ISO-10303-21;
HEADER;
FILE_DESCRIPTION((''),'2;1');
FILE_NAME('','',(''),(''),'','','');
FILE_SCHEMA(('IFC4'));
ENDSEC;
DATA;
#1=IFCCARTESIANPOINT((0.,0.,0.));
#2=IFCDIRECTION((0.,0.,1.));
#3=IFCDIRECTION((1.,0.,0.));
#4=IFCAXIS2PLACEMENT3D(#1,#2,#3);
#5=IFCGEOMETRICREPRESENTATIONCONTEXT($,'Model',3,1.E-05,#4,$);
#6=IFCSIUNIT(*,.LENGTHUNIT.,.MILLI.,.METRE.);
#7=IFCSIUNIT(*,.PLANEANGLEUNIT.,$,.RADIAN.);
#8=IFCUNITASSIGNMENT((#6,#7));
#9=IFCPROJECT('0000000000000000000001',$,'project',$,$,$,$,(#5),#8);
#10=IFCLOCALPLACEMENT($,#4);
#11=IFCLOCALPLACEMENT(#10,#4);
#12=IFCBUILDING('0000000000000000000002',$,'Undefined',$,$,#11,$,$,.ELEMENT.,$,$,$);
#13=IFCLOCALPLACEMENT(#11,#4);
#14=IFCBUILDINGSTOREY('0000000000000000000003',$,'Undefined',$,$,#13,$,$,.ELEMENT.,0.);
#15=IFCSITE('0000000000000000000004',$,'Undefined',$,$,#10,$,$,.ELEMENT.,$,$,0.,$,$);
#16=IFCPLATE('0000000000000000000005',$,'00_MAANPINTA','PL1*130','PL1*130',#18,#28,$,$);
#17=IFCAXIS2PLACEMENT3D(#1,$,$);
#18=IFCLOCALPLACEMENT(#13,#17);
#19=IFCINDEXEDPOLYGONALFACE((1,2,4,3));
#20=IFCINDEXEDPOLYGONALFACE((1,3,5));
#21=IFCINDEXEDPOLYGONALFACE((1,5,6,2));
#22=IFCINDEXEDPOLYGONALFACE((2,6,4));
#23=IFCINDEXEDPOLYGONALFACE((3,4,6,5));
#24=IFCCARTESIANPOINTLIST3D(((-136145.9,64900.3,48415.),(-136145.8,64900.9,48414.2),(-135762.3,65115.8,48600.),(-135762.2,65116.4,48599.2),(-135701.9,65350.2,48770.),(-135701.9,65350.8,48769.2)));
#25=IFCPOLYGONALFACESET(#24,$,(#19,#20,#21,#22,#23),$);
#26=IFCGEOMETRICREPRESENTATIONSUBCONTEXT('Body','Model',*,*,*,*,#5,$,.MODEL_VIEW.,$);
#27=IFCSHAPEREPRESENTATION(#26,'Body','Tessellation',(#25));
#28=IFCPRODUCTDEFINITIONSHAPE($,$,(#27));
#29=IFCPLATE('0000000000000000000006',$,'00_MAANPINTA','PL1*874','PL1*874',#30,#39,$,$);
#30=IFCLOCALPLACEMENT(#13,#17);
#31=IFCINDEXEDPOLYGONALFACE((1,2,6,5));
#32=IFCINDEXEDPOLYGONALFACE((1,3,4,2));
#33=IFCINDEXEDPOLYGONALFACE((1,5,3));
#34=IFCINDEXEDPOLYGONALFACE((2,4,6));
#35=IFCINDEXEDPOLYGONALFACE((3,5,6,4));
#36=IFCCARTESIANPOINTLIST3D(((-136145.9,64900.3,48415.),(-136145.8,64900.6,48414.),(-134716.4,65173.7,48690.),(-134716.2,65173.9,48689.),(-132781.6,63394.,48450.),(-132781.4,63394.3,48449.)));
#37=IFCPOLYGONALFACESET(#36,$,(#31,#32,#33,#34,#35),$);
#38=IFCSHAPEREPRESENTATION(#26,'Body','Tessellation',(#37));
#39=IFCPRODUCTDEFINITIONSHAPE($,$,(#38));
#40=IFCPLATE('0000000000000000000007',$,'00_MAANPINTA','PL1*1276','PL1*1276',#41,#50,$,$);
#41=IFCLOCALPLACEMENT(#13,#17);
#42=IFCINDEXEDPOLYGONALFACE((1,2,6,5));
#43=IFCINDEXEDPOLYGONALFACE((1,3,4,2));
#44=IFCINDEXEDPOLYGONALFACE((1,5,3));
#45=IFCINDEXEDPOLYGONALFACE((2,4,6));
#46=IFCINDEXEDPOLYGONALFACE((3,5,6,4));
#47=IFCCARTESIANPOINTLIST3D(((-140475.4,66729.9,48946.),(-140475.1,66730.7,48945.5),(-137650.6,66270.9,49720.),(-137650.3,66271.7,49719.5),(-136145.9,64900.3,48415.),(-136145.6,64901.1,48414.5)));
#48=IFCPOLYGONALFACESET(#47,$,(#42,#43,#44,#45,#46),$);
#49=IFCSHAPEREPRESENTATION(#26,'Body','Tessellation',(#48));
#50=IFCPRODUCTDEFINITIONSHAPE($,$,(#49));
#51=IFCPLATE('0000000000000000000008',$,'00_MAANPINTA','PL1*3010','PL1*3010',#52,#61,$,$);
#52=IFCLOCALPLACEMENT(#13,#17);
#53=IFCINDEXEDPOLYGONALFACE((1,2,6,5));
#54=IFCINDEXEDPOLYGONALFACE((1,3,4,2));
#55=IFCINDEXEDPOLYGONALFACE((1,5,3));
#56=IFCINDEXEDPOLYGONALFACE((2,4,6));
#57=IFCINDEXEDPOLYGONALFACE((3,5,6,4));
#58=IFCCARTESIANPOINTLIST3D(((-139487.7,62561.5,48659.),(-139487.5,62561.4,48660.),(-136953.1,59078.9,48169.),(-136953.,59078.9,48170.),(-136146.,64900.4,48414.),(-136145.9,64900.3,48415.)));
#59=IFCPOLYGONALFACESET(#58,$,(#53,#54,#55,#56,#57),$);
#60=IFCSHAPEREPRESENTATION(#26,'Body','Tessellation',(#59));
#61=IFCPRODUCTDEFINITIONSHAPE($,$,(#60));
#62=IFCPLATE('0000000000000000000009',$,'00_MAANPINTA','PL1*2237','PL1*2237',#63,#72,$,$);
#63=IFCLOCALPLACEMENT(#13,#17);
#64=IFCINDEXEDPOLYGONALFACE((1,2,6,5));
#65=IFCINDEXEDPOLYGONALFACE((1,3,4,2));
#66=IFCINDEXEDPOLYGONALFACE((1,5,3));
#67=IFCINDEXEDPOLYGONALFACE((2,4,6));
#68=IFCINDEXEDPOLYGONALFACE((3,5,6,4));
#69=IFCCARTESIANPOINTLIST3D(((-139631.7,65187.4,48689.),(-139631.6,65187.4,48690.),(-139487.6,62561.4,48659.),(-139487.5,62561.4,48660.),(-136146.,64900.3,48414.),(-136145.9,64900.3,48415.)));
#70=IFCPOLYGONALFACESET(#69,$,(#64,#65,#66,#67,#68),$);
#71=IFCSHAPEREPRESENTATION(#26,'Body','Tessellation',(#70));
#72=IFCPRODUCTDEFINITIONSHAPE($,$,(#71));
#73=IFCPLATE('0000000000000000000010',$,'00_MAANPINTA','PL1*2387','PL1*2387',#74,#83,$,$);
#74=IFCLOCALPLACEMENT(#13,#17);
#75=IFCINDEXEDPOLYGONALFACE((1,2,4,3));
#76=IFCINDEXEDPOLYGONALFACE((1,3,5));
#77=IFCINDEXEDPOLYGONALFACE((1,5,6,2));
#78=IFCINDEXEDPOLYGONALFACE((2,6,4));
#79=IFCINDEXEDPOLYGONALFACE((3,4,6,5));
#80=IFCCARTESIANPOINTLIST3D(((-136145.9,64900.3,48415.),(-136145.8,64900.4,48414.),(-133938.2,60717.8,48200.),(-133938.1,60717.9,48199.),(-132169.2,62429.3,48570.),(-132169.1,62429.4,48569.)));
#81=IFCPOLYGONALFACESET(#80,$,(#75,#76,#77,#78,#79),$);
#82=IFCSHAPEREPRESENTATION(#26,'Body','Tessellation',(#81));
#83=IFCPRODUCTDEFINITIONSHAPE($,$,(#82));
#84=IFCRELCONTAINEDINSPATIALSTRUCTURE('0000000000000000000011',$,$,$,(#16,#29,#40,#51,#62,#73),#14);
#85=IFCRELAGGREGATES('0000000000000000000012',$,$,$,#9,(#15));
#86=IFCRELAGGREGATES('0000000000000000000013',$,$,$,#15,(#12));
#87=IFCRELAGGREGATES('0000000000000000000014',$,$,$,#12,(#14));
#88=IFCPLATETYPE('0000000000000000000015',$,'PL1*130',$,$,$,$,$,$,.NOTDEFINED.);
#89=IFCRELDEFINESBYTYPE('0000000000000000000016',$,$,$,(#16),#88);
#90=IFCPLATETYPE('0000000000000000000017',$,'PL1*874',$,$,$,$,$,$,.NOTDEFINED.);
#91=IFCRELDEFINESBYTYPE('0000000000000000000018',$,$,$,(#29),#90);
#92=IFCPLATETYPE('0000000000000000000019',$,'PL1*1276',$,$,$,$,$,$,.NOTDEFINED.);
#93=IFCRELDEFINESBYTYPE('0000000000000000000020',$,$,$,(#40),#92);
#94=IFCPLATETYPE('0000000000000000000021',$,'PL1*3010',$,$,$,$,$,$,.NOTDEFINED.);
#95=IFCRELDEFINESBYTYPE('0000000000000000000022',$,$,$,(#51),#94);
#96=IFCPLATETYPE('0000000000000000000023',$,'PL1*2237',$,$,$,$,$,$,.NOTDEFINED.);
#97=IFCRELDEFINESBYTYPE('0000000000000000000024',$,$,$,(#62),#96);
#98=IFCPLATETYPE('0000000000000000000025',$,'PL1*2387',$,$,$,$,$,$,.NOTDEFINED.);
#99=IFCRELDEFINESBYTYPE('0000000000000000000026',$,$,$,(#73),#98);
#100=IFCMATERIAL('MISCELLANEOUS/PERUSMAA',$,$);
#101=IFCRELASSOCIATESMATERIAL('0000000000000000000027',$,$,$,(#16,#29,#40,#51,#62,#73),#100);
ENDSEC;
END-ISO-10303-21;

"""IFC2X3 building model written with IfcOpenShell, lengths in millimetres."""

from ifc_helpers import new_model, si_unit, frame, origin_with_axes, place, context, subcontext, project, spatial, polyline, outline, extrude, material, type_object, element, save


model = new_model("IFC2X3")

# Units and contexts
model_context = context("Model", 3, precision=1e-05, world=origin_with_axes())
body_context = subcontext(model_context, "Body", "Model", "MODEL_VIEW")
ifc_project = project(units=[si_unit("LENGTHUNIT", "METRE", prefix="MILLI"), si_unit("PLANEANGLEUNIT", "RADIAN")], contexts=[model_context])

# Site, building, storey
site_placement = place(None, origin_with_axes())
site = spatial("IfcSite", under=ifc_project, at=site_placement, Name="Undefined", CompositionType="ELEMENT", RefElevation=0.0)
building_placement = place(site_placement, origin_with_axes())
building = spatial("IfcBuilding", under=site, at=building_placement, Name="Undefined", CompositionType="ELEMENT")
storey_placement = place(building_placement, origin_with_axes())
storey = spatial("IfcBuildingStorey", under=building, at=storey_placement, Name="Undefined", CompositionType="ELEMENT", Elevation=0.0)

# Plates
ifc_material = material(Name="MISCELLANEOUS/PERUSMAA")
plate_type_1 = type_object("IfcPlateType", Name="PL1*130", PredefinedType="NOTDEFINED")
plate_1_placement = place(storey_placement, frame((-135762.3, 65116.1, 48599.6), z_axis=(0.071419, 0.573442, -0.816127), x_axis=(-0.803689, -0.451514, -0.387582)))
element("IfcPlate", 1, at=plate_1_placement, inside=storey, type_object=plate_type_1, material=ifc_material, Name="00_MAANPINTA", Description="PL1*130", ObjectType="PL1*130", context=body_context, shape_type="SweptSolid", body=[
    extrude(outline(polyline([(0.0, 0.0), (477.3, 0.0), (-220.3, 197.5), (0.0, 0.0)])), frame((0.0, 0.0, -0.5), z_axis=(0.0, 0.0, 1.0), x_axis=(1.0, 0.0, 0.0)), (0.0, 0.0, 1.0), 1.0),
])
plate_type_2 = type_object("IfcPlateType", Name="PL1*874", PredefinedType="NOTDEFINED")
plate_2_placement = place(storey_placement, frame((-136145.8, 64900.4, 48414.5), z_axis=(0.131484, 0.271523, -0.953408), x_axis=(0.965126, 0.184559, 0.185661)))
element("IfcPlate", 2, at=plate_2_placement, inside=storey, type_object=plate_type_2, material=ifc_material, Name="00_MAANPINTA", Description="PL1*874", ObjectType="PL1*874", context=body_context, shape_type="SweptSolid", body=[
    extrude(outline(polyline([(0.0, 0.0), (1481.2, 0.0), (2975.5, 2176.1), (0.0, 0.0)])), frame((0.0, 0.0, -0.5), z_axis=(0.0, 0.0, 1.0), x_axis=(1.0, 0.0, 0.0)), (0.0, 0.0, 1.0), 1.0),
])
plate_type_3 = type_object("IfcPlateType", Name="PL1*1276", PredefinedType="NOTDEFINED")
plate_3_placement = place(storey_placement, frame((-136145.8, 64900.7, 48414.7), z_axis=(0.275093, 0.803971, -0.527214), x_axis=(-0.915304, 0.386803, 0.112259)))
element("IfcPlate", 3, at=plate_3_placement, inside=storey, type_object=plate_type_3, material=ifc_material, Name="00_MAANPINTA", Description="PL1*1276", ObjectType="PL1*1276", context=body_context, shape_type="SweptSolid", body=[
    extrude(outline(polyline([(0.0, 0.0), (4730.1, 0.0), (2053.9, 1275.6), (0.0, 0.0)])), frame((0.0, 0.0, -0.5), z_axis=(0.0, 0.0, 1.0), x_axis=(1.0, 0.0, 0.0)), (0.0, 0.0, 1.0), 1.0),
])
plate_type_4 = type_object("IfcPlateType", Name="PL1*3010", PredefinedType="NOTDEFINED")
plate_4_placement = place(storey_placement, frame((-136146.0, 64900.3, 48414.5), z_axis=(-0.112902, 0.057399, -0.991947), x_axis=(-0.137203, -0.989667, -0.041651)))
element("IfcPlate", 4, at=plate_4_placement, inside=storey, type_object=plate_type_4, material=ifc_material, Name="00_MAANPINTA", Description="PL1*3010", ObjectType="PL1*3010", context=body_context, shape_type="SweptSolid", body=[
    extrude(outline(polyline([(0.0, 0.0), (5882.2, 0.0), (2763.0, 3010.4), (0.0, 0.0)])), frame((0.0, 0.0, -0.5), z_axis=(0.0, 0.0, 1.0), x_axis=(1.0, 0.0, 0.0)), (0.0, 0.0, 1.0), 1.0),
])
plate_type_5 = type_object("IfcPlateType", Name="PL1*2237", PredefinedType="NOTDEFINED")
plate_5_placement = place(storey_placement, frame((-139631.7, 65187.4, 48689.5), z_axis=(-0.078065, 0.007105, -0.996923), x_axis=(0.993559, -0.081828, -0.078385)))
element("IfcPlate", 5, at=plate_5_placement, inside=storey, type_object=plate_type_5, material=ifc_material, Name="00_MAANPINTA", Description="PL1*2237", ObjectType="PL1*2237", context=body_context, shape_type="SweptSolid", body=[
    extrude(outline(polyline([(0.0, 0.0), (3508.3, 0.0), (360.4, 2605.3), (0.0, 0.0)])), frame((0.0, 0.0, -0.5), z_axis=(0.0, 0.0, 1.0), x_axis=(1.0, 0.0, 0.0)), (0.0, 0.0, 1.0), 1.0),
])
plate_type_6 = type_object("IfcPlateType", Name="PL1*2387", PredefinedType="NOTDEFINED")
plate_6_placement = place(storey_placement, frame((-136145.9, 64900.3, 48414.5), z_axis=(0.104358, 0.105918, -0.988884), x_axis=(0.848914, -0.527494, 0.033088)))
element("IfcPlate", 6, at=plate_6_placement, inside=storey, type_object=plate_type_6, material=ifc_material, Name="00_MAANPINTA", Description="PL1*2387", ObjectType="PL1*2387", context=body_context, shape_type="SweptSolid", body=[
    extrude(outline(polyline([(0.0, 0.0), (4684.5, 0.0), (4073.3, 2412.9), (0.0, 0.0)])), frame((0.0, 0.0, -0.5), z_axis=(0.0, 0.0, 1.0), x_axis=(1.0, 0.0, 0.0)), (0.0, 0.0, 1.0), 1.0),
])

save(model, "model.ifc")
